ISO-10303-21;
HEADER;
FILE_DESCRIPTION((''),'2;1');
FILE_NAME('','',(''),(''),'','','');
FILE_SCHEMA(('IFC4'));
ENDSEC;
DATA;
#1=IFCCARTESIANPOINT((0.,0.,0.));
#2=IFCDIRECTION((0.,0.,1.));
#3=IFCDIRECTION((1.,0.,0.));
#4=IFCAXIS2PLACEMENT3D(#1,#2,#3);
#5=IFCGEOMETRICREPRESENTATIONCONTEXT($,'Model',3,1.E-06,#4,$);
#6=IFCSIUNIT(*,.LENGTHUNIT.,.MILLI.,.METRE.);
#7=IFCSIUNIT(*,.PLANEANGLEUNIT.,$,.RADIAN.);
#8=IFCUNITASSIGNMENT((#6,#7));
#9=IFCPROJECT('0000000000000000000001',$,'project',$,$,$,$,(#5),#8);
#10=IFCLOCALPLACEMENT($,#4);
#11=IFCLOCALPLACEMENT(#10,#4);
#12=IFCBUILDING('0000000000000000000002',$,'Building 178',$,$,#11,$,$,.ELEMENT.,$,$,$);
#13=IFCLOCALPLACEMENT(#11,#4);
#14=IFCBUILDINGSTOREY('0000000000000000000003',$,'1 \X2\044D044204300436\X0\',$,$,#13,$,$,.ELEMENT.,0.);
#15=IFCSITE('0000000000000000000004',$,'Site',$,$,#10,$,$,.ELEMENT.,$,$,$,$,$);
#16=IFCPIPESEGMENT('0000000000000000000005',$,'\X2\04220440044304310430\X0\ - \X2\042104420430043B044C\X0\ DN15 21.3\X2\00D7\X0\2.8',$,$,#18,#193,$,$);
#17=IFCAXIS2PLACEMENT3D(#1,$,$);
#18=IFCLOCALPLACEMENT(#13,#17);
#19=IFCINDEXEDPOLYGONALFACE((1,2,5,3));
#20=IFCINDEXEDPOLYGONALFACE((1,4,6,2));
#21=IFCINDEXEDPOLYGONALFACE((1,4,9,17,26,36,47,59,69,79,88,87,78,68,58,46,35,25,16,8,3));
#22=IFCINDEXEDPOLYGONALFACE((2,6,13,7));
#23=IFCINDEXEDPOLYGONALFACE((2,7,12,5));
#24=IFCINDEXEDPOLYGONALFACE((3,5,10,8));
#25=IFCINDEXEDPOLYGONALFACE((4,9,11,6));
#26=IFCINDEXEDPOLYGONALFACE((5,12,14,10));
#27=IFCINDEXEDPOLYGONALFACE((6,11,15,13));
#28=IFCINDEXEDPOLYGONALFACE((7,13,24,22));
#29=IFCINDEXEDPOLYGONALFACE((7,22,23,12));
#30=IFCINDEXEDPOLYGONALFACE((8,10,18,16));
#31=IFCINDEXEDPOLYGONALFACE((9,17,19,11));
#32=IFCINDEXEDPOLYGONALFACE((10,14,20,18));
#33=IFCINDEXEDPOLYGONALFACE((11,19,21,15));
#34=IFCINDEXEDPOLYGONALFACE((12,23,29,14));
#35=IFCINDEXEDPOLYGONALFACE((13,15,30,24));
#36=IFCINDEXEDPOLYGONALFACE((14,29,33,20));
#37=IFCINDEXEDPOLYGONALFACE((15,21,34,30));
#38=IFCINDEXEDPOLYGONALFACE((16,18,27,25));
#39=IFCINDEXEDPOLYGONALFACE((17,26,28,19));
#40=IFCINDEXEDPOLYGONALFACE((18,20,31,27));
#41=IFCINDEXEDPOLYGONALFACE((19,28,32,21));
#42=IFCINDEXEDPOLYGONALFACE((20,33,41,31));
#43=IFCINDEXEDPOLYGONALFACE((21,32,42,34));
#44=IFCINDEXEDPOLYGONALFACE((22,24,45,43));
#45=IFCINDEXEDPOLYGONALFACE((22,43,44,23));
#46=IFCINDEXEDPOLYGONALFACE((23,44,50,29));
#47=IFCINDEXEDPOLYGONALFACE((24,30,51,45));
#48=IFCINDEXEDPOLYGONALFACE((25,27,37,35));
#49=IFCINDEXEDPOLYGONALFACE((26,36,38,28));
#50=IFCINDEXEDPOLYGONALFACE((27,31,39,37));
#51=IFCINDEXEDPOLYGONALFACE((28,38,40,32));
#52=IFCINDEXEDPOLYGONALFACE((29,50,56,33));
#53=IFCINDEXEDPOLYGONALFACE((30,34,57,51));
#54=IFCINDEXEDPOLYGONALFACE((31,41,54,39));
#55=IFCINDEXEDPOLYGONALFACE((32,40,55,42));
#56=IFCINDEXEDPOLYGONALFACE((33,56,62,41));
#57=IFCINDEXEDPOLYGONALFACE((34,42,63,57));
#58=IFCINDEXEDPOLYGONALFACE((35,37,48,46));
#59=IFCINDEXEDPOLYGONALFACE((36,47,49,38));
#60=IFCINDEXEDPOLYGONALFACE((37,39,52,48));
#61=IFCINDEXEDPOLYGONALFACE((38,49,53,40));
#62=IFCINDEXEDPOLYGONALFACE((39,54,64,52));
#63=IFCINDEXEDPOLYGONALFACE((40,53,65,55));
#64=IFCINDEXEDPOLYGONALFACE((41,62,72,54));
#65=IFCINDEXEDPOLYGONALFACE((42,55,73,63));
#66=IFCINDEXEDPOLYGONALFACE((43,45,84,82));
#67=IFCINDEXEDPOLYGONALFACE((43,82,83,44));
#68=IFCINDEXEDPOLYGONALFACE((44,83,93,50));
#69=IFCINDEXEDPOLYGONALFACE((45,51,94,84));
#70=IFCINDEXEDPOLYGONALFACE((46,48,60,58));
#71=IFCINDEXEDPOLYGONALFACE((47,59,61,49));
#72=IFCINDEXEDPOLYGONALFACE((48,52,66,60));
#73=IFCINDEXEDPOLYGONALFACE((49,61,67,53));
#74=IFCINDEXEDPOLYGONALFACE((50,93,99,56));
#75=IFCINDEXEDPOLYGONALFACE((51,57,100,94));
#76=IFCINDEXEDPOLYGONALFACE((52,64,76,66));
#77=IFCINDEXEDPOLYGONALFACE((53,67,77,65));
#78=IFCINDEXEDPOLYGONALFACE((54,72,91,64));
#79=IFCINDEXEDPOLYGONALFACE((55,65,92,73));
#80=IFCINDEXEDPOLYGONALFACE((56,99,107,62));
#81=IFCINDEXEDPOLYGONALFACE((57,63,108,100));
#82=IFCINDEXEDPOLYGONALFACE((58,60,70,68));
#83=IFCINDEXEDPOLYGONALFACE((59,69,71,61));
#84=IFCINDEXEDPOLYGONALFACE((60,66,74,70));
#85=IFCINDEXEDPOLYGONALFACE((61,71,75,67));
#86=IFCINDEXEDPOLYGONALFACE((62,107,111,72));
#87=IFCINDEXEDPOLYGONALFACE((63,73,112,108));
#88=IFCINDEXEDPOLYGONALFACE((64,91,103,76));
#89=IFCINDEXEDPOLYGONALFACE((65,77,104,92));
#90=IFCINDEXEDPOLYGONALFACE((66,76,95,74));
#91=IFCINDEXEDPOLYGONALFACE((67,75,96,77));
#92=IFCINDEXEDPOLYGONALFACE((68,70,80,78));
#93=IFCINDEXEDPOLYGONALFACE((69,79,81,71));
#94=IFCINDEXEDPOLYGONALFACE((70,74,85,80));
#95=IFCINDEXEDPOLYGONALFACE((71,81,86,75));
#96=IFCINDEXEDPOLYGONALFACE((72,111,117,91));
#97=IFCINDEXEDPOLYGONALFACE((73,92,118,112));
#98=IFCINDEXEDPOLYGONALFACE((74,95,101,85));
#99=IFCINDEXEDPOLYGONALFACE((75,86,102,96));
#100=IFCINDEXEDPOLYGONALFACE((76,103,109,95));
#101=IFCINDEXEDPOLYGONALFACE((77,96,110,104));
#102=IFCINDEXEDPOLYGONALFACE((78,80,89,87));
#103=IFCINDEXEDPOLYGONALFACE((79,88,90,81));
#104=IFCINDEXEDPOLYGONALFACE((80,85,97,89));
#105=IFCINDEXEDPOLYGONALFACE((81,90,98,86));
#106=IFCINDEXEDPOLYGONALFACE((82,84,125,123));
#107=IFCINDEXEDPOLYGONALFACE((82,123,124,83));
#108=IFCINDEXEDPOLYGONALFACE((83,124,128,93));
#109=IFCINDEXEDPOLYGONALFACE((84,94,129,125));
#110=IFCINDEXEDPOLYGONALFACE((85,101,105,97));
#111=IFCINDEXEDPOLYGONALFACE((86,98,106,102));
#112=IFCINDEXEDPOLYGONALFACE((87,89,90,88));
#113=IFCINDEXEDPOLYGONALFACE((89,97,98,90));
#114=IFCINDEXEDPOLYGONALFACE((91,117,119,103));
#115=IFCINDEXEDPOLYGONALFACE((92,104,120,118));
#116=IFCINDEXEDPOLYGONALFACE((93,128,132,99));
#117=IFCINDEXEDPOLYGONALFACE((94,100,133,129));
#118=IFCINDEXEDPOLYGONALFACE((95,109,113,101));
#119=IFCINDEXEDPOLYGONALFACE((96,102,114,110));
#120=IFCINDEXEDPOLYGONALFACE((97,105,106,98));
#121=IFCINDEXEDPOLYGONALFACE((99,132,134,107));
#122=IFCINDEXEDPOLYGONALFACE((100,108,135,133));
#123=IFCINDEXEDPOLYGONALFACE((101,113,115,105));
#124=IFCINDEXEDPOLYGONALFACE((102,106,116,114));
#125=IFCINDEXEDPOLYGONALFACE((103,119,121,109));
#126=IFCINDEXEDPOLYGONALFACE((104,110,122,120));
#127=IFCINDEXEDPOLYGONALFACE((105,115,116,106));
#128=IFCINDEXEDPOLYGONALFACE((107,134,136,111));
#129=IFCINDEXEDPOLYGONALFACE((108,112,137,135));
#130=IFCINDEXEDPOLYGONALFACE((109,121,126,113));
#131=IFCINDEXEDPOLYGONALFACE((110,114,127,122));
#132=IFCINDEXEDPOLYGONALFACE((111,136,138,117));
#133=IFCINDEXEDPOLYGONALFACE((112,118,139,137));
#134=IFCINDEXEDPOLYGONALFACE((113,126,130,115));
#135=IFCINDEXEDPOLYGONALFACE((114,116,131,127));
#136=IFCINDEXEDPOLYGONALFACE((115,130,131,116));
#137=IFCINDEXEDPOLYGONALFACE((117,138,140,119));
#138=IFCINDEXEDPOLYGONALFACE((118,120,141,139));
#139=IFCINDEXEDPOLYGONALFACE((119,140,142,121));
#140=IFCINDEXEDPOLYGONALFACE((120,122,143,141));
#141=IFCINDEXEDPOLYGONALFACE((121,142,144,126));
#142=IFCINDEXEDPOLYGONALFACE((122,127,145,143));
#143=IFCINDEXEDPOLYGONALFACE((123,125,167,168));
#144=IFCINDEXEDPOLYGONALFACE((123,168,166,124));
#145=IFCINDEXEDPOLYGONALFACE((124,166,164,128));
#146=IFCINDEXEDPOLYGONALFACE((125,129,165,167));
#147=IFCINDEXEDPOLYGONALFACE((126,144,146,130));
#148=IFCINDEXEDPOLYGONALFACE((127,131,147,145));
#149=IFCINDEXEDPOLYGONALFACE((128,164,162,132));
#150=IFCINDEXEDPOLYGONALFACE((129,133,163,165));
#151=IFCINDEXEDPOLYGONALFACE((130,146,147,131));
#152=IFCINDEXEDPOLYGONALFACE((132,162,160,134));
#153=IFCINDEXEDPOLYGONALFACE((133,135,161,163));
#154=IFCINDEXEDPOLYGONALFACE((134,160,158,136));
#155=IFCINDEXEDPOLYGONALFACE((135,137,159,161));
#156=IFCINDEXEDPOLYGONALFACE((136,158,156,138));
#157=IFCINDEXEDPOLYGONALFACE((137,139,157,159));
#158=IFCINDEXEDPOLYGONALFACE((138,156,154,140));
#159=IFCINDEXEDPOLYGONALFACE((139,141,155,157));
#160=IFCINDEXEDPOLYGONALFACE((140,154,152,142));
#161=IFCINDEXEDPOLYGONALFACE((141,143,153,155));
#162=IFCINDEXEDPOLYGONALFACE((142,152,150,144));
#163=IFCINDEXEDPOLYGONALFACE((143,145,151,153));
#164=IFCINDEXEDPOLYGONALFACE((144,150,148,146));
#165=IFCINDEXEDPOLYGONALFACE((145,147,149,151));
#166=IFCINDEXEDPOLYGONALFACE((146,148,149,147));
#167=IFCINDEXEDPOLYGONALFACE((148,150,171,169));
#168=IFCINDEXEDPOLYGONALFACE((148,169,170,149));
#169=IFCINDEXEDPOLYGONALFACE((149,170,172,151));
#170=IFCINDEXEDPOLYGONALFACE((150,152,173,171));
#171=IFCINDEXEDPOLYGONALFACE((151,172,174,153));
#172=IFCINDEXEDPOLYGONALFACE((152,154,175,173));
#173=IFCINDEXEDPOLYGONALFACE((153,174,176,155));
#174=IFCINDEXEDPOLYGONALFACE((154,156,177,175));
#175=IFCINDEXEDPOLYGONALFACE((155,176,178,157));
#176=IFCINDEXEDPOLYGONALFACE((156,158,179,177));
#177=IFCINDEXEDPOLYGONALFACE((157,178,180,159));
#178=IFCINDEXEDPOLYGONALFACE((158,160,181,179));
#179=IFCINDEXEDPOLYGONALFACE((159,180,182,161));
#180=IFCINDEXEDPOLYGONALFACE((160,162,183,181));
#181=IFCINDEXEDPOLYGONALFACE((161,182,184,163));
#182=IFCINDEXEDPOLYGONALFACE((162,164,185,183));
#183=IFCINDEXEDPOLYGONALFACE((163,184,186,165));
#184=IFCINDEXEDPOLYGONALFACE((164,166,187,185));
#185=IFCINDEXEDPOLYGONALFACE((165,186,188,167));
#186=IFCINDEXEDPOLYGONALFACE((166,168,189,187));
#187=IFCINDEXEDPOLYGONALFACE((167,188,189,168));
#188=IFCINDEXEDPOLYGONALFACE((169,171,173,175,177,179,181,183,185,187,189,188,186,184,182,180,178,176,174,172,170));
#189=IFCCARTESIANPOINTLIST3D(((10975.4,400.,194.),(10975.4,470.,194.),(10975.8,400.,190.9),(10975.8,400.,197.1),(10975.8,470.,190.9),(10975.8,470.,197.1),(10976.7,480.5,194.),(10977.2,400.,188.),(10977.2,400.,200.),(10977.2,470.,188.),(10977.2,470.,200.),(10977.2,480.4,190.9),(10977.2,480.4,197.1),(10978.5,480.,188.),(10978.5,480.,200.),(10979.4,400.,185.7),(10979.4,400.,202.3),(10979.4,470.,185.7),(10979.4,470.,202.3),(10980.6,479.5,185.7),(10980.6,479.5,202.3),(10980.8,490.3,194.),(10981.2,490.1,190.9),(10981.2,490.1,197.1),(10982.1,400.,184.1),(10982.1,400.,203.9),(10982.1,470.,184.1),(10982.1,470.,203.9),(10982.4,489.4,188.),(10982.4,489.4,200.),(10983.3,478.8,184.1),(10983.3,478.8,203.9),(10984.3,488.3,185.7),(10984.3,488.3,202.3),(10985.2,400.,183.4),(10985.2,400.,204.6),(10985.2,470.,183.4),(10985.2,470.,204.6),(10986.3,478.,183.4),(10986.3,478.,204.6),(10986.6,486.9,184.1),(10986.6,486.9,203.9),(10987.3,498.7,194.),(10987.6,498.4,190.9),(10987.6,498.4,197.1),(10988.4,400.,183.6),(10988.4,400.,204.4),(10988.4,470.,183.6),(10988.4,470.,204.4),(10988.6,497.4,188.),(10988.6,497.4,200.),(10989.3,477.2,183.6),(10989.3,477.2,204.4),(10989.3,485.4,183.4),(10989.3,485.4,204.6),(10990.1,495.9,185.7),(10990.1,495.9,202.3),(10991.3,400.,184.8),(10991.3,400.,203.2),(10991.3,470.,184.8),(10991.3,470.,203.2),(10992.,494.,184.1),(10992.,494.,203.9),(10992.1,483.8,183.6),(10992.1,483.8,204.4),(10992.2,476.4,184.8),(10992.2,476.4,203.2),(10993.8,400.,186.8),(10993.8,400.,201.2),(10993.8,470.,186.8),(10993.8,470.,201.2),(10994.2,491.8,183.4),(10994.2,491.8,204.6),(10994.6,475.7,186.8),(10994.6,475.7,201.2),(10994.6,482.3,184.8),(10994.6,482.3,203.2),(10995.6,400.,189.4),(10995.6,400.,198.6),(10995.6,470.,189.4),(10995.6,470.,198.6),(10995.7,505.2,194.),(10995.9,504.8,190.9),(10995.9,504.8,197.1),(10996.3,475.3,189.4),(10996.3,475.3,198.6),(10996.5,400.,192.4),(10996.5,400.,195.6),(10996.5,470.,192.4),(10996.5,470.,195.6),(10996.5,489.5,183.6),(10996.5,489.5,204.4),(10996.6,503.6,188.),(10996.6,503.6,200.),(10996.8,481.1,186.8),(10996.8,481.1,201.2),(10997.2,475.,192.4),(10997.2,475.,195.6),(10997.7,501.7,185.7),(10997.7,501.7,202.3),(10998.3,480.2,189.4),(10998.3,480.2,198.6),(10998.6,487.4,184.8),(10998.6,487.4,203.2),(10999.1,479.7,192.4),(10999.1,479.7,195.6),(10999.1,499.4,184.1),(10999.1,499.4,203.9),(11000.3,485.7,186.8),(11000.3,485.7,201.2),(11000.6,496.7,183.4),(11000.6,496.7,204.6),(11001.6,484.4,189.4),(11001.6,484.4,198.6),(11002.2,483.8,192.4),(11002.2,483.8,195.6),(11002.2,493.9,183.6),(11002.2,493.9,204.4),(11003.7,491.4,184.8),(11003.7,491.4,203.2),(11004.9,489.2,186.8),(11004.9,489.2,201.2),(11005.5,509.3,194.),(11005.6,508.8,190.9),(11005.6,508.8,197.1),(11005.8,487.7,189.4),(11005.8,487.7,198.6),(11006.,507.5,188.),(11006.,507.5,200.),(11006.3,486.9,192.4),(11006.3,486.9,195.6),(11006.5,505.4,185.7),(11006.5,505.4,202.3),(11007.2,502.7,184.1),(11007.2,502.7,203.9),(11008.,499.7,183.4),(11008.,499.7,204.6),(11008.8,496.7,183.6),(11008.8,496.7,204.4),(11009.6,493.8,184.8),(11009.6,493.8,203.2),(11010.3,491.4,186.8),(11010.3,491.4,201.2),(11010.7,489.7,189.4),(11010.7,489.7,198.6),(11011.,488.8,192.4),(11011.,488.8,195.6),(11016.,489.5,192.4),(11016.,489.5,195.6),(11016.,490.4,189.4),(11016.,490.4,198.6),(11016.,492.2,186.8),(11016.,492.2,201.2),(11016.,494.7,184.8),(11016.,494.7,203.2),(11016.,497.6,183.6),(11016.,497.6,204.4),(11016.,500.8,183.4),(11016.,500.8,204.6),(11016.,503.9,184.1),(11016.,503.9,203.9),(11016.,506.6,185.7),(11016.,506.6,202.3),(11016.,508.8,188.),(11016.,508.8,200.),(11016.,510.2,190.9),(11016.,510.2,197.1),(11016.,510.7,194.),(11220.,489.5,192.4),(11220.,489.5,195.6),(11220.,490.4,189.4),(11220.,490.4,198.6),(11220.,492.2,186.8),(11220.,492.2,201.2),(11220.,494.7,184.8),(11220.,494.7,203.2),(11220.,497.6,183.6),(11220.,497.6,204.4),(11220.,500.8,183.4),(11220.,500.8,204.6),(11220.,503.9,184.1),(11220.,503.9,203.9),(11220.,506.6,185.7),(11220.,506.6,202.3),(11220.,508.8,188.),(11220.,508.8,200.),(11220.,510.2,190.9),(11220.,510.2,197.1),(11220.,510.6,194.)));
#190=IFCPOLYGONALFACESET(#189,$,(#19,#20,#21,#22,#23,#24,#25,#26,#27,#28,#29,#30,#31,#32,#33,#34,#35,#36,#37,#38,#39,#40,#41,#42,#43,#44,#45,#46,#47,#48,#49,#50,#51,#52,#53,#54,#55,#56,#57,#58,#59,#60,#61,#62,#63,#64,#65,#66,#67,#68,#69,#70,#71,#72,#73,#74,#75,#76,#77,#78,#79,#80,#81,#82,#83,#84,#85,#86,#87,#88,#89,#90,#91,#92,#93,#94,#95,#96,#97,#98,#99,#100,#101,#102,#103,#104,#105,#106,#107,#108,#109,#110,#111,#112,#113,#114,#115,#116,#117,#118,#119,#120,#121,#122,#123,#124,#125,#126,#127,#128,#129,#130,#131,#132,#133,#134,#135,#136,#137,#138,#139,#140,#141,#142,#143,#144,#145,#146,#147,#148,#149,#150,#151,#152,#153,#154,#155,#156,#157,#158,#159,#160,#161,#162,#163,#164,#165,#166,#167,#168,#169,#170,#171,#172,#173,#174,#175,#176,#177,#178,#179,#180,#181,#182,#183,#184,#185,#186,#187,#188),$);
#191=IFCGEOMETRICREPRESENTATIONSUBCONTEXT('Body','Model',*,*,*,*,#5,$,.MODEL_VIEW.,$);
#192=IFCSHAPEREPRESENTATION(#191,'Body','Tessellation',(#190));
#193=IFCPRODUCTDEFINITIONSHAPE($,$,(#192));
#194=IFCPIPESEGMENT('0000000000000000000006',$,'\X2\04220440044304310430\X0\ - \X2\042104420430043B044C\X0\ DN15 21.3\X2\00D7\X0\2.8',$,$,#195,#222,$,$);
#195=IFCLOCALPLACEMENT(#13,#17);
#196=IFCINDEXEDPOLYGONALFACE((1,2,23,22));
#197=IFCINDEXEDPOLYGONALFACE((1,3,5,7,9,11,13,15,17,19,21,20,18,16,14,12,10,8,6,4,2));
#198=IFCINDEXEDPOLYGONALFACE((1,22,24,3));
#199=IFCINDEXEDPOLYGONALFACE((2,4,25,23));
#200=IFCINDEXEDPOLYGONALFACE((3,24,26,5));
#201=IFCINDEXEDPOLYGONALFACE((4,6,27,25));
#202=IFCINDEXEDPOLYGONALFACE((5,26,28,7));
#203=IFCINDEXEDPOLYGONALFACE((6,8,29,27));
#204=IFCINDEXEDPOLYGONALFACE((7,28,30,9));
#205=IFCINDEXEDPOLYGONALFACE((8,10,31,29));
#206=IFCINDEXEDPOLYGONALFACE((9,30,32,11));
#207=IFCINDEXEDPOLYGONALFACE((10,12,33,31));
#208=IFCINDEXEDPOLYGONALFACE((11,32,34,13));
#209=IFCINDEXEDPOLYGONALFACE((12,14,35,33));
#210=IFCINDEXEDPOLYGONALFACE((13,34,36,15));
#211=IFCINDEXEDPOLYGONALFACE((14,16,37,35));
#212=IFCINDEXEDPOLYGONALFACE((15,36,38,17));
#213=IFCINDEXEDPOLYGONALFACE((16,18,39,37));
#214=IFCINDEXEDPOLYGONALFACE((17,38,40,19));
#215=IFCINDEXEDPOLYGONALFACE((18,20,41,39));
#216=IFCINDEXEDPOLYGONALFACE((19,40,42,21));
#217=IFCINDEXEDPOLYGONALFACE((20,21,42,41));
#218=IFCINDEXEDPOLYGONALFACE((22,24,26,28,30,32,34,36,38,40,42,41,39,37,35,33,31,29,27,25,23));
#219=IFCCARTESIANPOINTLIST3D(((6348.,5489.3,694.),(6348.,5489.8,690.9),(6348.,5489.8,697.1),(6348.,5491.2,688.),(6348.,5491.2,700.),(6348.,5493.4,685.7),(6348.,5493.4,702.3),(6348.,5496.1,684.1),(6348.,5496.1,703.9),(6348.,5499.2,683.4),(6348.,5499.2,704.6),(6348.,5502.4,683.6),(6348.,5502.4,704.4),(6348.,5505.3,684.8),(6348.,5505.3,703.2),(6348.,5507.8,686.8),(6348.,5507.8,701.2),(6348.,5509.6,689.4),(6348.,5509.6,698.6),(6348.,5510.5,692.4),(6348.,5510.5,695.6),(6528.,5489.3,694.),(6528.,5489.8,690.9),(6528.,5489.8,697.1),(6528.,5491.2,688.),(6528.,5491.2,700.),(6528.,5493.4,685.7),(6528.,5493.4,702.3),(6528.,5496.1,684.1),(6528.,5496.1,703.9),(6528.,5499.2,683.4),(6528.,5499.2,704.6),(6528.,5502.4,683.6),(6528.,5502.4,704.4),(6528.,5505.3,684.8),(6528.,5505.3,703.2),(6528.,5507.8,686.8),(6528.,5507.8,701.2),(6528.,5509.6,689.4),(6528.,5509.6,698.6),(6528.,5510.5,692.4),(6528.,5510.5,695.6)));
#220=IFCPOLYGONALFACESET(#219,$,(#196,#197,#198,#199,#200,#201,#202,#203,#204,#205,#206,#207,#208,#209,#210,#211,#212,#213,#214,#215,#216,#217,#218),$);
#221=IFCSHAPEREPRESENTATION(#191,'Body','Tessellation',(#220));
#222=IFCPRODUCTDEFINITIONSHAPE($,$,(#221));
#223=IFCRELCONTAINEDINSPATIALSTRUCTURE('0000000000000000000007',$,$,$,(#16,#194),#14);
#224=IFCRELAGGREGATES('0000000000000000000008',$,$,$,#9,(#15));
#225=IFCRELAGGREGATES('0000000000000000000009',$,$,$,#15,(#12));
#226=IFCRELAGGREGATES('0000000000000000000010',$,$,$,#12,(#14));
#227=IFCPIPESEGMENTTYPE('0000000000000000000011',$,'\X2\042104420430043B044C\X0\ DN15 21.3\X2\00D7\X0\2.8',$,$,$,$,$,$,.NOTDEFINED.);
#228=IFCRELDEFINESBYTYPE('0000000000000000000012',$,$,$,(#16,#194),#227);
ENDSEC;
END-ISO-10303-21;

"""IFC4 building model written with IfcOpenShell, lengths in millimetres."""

from ifc_helpers import new_model, entity, si_unit, frame, origin_with_axes, place, context, subcontext, project, spatial, source, transform, mapped, type_object, element, save


model = new_model("IFC4")

# Units and contexts
model_context = context("Model", 3, precision=1e-06, world=origin_with_axes())
body_context = subcontext(model_context, "Body", "Model", "MODEL_VIEW")
ifc_project = project(units=[si_unit("LENGTHUNIT", "METRE", prefix="MILLI"), si_unit("PLANEANGLEUNIT", "RADIAN")], contexts=[model_context])

# Site, building, storey
site_placement = place(None, origin_with_axes())
site = spatial("IfcSite", under=ifc_project, at=site_placement, Name="Site", CompositionType="ELEMENT")
building_placement = place(site_placement, origin_with_axes())
building = spatial("IfcBuilding", under=site, at=building_placement, Name="Building 178", CompositionType="ELEMENT")
storey_placement = place(building_placement, origin_with_axes())
storey = spatial("IfcBuildingStorey", under=building, at=storey_placement, Name="1 этаж", CompositionType="ELEMENT", Elevation=0.0)

# Pipe segments
pipe_segment_type = type_object("IfcPipeSegmentType", Name="Сталь DN15 21.3×2.8", PredefinedType="NOTDEFINED")
shared_shape_1 = source(origin_with_axes(), body_context, "Body", "AdvancedSweptSolid", [
    entity("IfcSweptDiskSolid", entity("IfcIndexedPolyCurve", entity("IfcCartesianPointList3D", [[0.0, 0.0, 0.0], [0.0, 0.0, -70.0], [8.8, 0.0, -91.2], [30.0, 0.0, -100.0], [234.0, 0.0, -100.0]]), [entity("IfcLineIndex", [1, 2]), entity("IfcArcIndex", [2, 3, 4]), entity("IfcLineIndex", [4, 5])]), 10.7),
])
for number, where, z_axis, x_axis, name in (
    (1, (10986.0, 400.0, 194.0), (0.0, -1.0, 0.0), (1.0, 0.0, 0.0), "Труба - Сталь DN15 21.3×2.8"),
):
    element("IfcPipeSegment", number, at=place(storey_placement, frame(where, z_axis=z_axis, x_axis=x_axis)), inside=storey, type_object=pipe_segment_type, Name=name, context=body_context, shape_type="MappedRepresentation", body=[
        mapped(shared_shape_1, transform((0.0, 0.0, 0.0), x_axis=(1.0, 0.0, 0.0), y_axis=(0.0, 1.0, 0.0), z_axis=(0.0, 0.0, 1.0), scale=1.0)),
    ])
shared_shape_2 = source(origin_with_axes(), body_context, "Body", "AdvancedSweptSolid", [
    entity("IfcSweptDiskSolid", entity("IfcIndexedPolyCurve", entity("IfcCartesianPointList3D", [[0.0, 0.0, 0.0], [0.0, 0.0, -180.0]]), [entity("IfcLineIndex", [1, 2])]), 10.7),
])
for number, where, z_axis, x_axis, name in (
    (2, (6528.0, 5500.0, 694.0), (1.0, 0.0, 0.0), (0.0, 1.0, 0.0), "Труба - Сталь DN15 21.3×2.8"),
):
    element("IfcPipeSegment", number, at=place(storey_placement, frame(where, z_axis=z_axis, x_axis=x_axis)), inside=storey, type_object=pipe_segment_type, Name=name, context=body_context, shape_type="MappedRepresentation", body=[
        mapped(shared_shape_2, transform((0.0, 0.0, 0.0), x_axis=(1.0, 0.0, 0.0), y_axis=(0.0, 1.0, 0.0), z_axis=(0.0, 0.0, 1.0), scale=1.0)),
    ])

save(model, "model.ifc")
